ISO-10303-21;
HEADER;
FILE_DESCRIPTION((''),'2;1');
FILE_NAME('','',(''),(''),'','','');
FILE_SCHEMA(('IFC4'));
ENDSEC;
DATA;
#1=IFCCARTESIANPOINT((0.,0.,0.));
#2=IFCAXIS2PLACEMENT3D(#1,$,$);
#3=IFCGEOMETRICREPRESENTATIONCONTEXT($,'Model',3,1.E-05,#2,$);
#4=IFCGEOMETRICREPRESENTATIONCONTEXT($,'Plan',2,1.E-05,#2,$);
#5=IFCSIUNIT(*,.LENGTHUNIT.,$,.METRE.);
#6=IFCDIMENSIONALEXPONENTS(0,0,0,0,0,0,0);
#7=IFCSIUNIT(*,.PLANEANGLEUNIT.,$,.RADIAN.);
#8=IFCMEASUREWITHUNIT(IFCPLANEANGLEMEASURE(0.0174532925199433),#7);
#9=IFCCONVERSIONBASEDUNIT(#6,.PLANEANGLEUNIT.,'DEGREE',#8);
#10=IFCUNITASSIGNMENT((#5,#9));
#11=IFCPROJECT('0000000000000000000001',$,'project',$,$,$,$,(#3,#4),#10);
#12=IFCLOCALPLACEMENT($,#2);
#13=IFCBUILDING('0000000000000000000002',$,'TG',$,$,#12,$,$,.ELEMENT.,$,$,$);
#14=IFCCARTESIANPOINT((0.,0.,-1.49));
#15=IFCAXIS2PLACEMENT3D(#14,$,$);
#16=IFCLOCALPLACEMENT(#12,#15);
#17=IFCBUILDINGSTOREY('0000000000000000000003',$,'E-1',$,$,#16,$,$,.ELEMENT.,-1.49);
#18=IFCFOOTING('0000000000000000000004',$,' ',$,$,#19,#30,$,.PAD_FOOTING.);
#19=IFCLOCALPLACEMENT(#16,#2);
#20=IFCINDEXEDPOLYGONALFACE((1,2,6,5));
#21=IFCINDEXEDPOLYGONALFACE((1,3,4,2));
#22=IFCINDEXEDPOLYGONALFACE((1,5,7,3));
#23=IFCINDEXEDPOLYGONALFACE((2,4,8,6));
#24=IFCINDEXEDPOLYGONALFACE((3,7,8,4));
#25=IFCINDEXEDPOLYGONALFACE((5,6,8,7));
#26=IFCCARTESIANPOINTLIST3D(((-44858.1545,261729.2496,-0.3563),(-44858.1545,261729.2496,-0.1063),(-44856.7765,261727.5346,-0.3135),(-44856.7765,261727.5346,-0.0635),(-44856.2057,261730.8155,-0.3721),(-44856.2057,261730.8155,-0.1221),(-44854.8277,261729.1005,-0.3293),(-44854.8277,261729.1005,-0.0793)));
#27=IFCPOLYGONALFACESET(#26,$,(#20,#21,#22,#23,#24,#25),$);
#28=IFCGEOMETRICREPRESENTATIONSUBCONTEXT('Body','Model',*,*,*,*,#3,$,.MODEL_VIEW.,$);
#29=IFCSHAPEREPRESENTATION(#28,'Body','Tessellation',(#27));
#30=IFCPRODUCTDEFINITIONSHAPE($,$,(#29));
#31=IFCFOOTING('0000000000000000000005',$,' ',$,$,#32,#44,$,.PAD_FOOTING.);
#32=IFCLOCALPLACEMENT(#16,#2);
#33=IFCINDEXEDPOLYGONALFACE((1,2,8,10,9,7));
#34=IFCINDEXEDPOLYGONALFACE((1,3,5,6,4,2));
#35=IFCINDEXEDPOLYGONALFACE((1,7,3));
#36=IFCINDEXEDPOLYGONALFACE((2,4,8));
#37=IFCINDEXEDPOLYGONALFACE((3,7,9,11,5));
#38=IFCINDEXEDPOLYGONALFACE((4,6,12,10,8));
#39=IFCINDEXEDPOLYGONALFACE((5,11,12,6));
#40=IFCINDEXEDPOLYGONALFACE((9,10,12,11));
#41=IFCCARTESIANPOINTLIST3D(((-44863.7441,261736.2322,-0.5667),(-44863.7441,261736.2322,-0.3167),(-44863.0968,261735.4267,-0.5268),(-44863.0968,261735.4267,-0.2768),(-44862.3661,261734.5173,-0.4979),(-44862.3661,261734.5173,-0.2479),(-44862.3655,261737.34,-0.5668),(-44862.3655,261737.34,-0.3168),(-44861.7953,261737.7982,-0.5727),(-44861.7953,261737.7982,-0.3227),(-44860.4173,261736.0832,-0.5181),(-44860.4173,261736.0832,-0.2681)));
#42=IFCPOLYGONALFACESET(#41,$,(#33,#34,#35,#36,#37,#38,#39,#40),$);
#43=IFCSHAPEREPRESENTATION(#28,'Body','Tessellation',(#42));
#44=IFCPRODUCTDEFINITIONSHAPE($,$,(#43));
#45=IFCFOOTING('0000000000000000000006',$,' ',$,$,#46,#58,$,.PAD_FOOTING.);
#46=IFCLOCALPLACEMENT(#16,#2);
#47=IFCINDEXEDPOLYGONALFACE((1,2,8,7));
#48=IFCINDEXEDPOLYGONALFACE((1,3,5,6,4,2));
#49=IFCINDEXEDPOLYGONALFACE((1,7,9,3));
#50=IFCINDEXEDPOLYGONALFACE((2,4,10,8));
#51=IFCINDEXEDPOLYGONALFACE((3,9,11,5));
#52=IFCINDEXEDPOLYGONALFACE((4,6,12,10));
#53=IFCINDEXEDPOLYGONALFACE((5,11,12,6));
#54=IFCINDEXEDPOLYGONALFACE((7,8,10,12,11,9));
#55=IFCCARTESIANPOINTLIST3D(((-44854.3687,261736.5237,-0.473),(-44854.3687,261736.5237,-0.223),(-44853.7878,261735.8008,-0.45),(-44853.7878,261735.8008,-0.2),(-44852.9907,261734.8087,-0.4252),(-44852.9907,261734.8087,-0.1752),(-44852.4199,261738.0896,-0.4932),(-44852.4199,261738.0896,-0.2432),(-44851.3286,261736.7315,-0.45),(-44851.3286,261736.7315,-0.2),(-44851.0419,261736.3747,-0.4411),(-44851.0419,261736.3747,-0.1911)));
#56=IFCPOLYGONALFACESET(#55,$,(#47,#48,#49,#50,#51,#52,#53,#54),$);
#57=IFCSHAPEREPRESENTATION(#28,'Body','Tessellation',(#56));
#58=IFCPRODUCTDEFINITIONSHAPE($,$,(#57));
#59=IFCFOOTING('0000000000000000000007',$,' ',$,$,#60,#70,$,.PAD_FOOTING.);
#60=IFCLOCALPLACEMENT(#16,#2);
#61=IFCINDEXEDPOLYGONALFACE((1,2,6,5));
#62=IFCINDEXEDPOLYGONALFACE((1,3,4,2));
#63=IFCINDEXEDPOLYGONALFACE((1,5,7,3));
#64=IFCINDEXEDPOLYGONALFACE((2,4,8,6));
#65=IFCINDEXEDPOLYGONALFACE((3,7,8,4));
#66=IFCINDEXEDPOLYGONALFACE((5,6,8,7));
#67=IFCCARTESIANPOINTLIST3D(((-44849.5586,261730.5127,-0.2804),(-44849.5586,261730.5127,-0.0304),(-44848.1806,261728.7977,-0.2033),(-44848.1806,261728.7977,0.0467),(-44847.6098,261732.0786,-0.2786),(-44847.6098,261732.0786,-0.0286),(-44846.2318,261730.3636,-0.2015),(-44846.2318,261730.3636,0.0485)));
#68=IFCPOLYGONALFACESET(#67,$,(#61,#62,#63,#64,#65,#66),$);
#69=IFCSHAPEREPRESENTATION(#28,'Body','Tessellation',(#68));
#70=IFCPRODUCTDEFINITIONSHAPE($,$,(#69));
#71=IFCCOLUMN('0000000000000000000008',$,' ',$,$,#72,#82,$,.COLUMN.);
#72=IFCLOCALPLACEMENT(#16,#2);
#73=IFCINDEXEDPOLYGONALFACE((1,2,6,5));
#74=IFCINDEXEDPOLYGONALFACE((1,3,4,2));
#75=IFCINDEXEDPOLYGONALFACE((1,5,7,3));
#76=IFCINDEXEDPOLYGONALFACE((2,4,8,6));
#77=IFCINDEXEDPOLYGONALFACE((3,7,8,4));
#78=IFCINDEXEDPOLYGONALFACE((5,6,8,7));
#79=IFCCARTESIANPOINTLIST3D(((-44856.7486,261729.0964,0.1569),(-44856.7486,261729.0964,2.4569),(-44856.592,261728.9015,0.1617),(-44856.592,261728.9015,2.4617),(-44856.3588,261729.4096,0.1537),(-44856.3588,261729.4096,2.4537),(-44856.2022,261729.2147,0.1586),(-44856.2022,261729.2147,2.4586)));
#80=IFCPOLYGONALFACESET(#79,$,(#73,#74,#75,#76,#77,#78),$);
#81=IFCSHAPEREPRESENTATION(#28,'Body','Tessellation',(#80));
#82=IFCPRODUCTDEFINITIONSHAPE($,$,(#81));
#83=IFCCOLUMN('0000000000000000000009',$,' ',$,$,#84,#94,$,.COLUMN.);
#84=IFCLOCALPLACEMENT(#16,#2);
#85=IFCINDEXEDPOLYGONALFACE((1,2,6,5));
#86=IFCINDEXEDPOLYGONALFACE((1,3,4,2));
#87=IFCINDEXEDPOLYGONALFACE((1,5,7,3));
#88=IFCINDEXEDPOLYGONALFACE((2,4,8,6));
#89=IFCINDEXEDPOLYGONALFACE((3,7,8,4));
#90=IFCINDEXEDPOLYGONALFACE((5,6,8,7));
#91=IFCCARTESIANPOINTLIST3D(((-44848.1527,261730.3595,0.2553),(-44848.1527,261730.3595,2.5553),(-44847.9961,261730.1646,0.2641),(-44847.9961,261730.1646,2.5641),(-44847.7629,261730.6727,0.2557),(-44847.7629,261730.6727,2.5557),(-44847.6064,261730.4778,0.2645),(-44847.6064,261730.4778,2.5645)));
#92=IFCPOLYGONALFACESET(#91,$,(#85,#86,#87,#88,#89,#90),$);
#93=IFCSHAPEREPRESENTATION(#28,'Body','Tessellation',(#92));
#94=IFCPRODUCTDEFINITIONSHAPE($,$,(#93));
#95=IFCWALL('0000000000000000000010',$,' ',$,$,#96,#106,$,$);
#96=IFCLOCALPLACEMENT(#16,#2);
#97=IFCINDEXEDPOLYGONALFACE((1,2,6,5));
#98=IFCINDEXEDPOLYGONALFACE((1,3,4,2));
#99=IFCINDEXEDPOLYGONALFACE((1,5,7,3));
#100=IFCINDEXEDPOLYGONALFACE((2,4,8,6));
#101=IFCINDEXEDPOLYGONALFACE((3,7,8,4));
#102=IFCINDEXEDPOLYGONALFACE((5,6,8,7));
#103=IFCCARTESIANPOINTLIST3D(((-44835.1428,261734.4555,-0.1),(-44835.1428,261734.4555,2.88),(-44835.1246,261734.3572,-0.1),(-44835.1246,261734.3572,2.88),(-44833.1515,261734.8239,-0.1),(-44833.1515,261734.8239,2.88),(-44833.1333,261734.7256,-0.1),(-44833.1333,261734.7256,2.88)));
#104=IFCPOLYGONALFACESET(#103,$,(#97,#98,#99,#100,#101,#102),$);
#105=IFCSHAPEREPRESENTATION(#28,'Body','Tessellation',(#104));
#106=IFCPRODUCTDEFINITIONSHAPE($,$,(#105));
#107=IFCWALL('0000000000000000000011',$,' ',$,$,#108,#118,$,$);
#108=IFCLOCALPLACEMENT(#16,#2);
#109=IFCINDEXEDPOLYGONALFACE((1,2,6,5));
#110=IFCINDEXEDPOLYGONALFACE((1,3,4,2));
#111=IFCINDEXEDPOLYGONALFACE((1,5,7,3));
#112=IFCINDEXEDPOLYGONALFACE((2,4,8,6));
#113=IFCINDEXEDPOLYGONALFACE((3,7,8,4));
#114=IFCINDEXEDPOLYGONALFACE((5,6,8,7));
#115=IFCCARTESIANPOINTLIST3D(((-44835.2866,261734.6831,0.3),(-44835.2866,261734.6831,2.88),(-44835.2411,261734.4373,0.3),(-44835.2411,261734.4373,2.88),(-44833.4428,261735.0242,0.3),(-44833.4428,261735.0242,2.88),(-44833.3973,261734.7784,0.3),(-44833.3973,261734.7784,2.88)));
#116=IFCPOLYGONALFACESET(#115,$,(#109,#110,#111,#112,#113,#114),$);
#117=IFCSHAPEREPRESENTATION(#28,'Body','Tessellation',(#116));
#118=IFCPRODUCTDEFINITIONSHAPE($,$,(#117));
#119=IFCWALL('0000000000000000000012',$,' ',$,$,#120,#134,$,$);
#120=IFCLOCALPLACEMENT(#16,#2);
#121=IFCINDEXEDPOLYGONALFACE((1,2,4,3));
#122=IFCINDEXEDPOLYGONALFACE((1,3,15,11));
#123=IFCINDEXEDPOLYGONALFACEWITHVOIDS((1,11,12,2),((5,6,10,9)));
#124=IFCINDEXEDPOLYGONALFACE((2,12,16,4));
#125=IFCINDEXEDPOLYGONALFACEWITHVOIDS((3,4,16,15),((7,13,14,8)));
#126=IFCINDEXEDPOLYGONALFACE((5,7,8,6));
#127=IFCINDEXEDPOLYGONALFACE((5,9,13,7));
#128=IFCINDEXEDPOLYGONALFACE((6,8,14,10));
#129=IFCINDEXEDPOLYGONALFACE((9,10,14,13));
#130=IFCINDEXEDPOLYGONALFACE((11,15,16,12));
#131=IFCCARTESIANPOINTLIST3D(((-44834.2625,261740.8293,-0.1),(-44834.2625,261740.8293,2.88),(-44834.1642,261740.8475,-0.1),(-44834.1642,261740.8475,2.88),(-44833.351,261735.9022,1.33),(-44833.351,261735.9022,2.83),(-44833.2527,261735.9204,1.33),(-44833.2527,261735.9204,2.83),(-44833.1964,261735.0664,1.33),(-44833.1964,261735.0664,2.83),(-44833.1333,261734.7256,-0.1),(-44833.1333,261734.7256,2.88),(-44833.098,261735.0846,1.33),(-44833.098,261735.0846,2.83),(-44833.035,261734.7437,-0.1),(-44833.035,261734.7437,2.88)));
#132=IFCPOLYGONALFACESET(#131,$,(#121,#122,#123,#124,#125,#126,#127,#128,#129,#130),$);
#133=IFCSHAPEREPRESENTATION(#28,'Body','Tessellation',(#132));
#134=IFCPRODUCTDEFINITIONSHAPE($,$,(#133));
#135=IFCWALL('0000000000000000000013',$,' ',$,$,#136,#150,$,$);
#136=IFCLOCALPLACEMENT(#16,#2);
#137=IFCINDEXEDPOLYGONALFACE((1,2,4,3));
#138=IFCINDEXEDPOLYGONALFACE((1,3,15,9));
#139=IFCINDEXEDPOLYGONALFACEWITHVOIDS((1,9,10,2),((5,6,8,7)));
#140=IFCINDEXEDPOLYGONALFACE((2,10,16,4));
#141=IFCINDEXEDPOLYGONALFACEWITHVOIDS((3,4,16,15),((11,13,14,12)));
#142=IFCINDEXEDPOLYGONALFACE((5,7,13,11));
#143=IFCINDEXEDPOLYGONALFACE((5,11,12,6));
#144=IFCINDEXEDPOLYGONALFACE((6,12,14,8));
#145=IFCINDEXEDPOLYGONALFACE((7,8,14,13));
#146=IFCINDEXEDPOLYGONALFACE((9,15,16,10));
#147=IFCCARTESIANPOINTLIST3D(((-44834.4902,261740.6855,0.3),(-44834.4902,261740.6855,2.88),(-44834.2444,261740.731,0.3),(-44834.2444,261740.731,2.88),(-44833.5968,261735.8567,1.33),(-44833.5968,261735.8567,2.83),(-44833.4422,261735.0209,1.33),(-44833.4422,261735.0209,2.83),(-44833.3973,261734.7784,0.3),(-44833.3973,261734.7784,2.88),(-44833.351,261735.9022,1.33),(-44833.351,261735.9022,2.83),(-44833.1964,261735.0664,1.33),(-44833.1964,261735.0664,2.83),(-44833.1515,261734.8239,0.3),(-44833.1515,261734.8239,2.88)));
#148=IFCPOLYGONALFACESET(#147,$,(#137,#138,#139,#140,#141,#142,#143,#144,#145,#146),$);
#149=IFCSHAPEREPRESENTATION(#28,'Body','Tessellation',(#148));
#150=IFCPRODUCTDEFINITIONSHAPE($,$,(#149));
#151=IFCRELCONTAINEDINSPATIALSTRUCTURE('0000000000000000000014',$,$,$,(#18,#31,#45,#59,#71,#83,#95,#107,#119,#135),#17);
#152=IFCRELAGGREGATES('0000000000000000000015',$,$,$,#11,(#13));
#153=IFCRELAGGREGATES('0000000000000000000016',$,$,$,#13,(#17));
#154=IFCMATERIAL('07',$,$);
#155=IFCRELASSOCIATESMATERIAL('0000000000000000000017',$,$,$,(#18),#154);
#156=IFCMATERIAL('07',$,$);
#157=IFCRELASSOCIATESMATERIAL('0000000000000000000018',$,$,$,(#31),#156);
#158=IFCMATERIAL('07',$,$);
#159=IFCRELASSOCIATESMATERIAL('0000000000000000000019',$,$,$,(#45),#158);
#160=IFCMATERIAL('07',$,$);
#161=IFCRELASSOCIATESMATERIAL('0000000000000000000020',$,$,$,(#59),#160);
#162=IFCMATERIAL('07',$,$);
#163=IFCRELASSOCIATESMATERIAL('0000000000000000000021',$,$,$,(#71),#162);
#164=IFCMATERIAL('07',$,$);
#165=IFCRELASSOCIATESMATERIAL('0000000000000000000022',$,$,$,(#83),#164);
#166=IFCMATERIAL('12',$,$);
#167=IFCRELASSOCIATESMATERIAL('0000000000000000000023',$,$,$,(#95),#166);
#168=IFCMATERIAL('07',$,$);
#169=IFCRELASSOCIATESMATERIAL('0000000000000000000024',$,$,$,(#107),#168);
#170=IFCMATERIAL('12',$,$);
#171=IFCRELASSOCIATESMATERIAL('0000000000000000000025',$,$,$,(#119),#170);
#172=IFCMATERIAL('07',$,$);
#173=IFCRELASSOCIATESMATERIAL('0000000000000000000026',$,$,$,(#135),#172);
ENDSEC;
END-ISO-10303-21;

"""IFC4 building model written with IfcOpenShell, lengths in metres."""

from ifc_helpers import new_model, entity, si_unit, converted_unit, frame, frame_2d, origin, origin_with_axes, place, context, subcontext, project, spatial, polyline, rectangle, outline, extrude, clip, halfspace, bounded_halfspace, material, element, save


model = new_model("IFC4")

# Units and contexts
model_context = context("Model", 3, precision=1e-05, world=origin())
plan_context = context("Plan", 2, precision=1e-05, world=origin())
body_context = subcontext(model_context, "Body", "Model", "MODEL_VIEW")
ifc_project = project(units=[si_unit("LENGTHUNIT", "METRE"), converted_unit("PLANEANGLEUNIT", "DEGREE", entity("IfcPlaneAngleMeasure", 0.0174532925199433), si_unit("PLANEANGLEUNIT", "RADIAN"), dimensions=[0, 0, 0, 0, 0, 0, 0])], contexts=[model_context, plan_context])

# Building, storey
building_placement = place(None, origin())
building = spatial("IfcBuilding", under=ifc_project, at=building_placement, Name="TG", CompositionType="ELEMENT")
storey_placement = place(building_placement, frame((0.0, 0.0, -1.49)))
storey = spatial("IfcBuildingStorey", under=building, at=storey_placement, Name="E-1", CompositionType="ELEMENT", Elevation=-1.49)

# Footings
ifc_material_1 = material(Name="07")
footing_1_placement = place(storey_placement, frame((-44858.1545, 261727.5346, -0.3721)))
element("IfcFooting", 1, at=footing_1_placement, inside=storey, material=ifc_material_1, Name=" ", PredefinedType="PAD_FOOTING", context=body_context, shape_type="Clipping", body=[
    clip(clip(extrude(rectangle(XDim=2.5, YDim=2.2, at=frame_2d((0.2854, 1.6404), x_axis=(0.779531, 0.626364))), frame((1.378, 0.0, 0.0), z_axis=(0.0, 0.0, 1.0), x_axis=(1.0, 0.0, 0.0)), (0.0, 0.0, 1.0), 0.3087), halfspace(frame((1.6634, 1.6404, 0.0293), z_axis=(-0.00724, 0.019133, 0.999791), x_axis=(0.626245, -0.779383, 0.01945)), True)), halfspace(frame((1.6634, 1.6404, 0.2793), z_axis=(0.00724, -0.019133, -0.999791), x_axis=(0.779515, 0.626351, -0.006341)), True)),
])
ifc_material_2 = material(Name="07")
footing_2_placement = place(storey_placement, frame((-44863.7441, 261734.5173, -0.5727)))
element("IfcFooting", 2, at=footing_2_placement, inside=storey, material=ifc_material_2, Name=" ", PredefinedType="PAD_FOOTING", context=body_context, shape_type="Clipping", body=[
    clip(clip(clip(clip(extrude(rectangle(XDim=2.5, YDim=2.2, at=frame_2d((0.2854, 1.6404), x_axis=(0.779531, 0.626364))), frame((1.378, 0.0, 0.0), z_axis=(0.0, 0.0, 1.0), x_axis=(1.0, 0.0, 0.0)), (0.0, 0.0, 1.0), 0.3248), bounded_halfspace(frame((1.7359, 1.7158, 0.0362), z_axis=(-0.009231, 0.024393, 0.99966), x_axis=(-0.626171, 0.779291, -0.024798)), True, origin_with_axes(), polyline([(3.3268, 1.5659), (1.9488, 3.2809), (1.3787, 2.8227), (0.6473, 0.9094), (1.378, 0.0), (3.3268, 1.5659)]))), bounded_halfspace(frame((0.6753, 1.8157, 0.0193), z_axis=(-0.024077, 0.03006, 0.999258), x_axis=(0.356977, 0.93391, -0.019493)), True, origin_with_axes(), polyline([(0.6473, 0.9094), (1.3787, 2.8227), (0.0, 1.715), (0.6473, 0.9094)]))), bounded_halfspace(frame((1.7359, 1.7158, 0.2862), z_axis=(0.009231, -0.024393, -0.99966), x_axis=(-0.779505, -0.626343, 0.008086)), True, origin_with_axes(), polyline([(1.9488, 3.2809), (1.3787, 2.8227), (0.6473, 0.9094), (1.378, 0.0), (3.3268, 1.5659), (1.9488, 3.2809)]))), bounded_halfspace(frame((0.6753, 1.8157, 0.2693), z_axis=(0.024077, -0.03006, -0.999258), x_axis=(-0.779531, -0.626364, 0.00006)), True, origin_with_axes(), polyline([(1.3787, 2.8227), (0.0, 1.715), (0.6473, 0.9094), (1.3787, 2.8227)]))),
])
ifc_material_3 = material(Name="07")
footing_3_placement = place(storey_placement, frame((-44854.3687, 261734.8087, -0.4932)))
element("IfcFooting", 3, at=footing_3_placement, inside=storey, material=ifc_material_3, Name=" ", PredefinedType="PAD_FOOTING", context=body_context, shape_type="Clipping", body=[
    clip(clip(clip(clip(extrude(rectangle(XDim=2.5, YDim=2.2, at=frame_2d((0.2854, 1.6404), x_axis=(0.779531, 0.626364))), frame((1.378, 0.0, 0.0), z_axis=(0.0, 0.0, 1.0), x_axis=(1.0, 0.0, 0.0)), (0.0, 0.0, 1.0), 0.318), bounded_halfspace(frame((2.0815, 1.1202, 0.0516), z_axis=(-0.00724, 0.019133, 0.999791), x_axis=(0.779515, 0.626351, -0.006341)), True, origin_with_axes(), polyline([(1.378, 0.0), (3.3268, 1.5659), (3.0401, 1.9227), (0.5809, 0.9921), (1.378, 0.0)]))), bounded_halfspace(frame((1.3925, 1.9777, 0.0267), z_axis=(-0.009231, 0.024393, 0.99966), x_axis=(0.626171, -0.779291, 0.024798)), True, origin_with_axes(), polyline([(0.0, 1.715), (0.5809, 0.9921), (3.0401, 1.9227), (1.9488, 3.2809), (0.0, 1.715)]))), bounded_halfspace(frame((2.0815, 1.1202, 0.3016), z_axis=(0.00724, -0.019133, -0.999791), x_axis=(-0.626245, 0.779383, -0.01945)), True, origin_with_axes(), polyline([(3.3268, 1.5659), (3.0401, 1.9227), (0.5809, 0.9921), (1.378, 0.0), (3.3268, 1.5659)]))), bounded_halfspace(frame((1.3925, 1.9777, 0.2767), z_axis=(0.009231, -0.024393, -0.99966), x_axis=(0.935274, 0.353924, 0.0)), True, origin_with_axes(), polyline([(0.5809, 0.9921), (3.0401, 1.9227), (1.9488, 3.2809), (0.0, 1.715), (0.5809, 0.9921)]))),
])
ifc_material_4 = material(Name="07")
footing_4_placement = place(storey_placement, frame((-44849.5586, 261728.7977, -0.2804)))
element("IfcFooting", 4, at=footing_4_placement, inside=storey, material=ifc_material_4, Name=" ", PredefinedType="PAD_FOOTING", context=body_context, shape_type="Clipping", body=[
    clip(clip(extrude(rectangle(XDim=2.5, YDim=2.2, at=frame_2d((0.2854, 1.6404), x_axis=(0.779531, 0.626364))), frame((1.378, 0.0, 0.0), z_axis=(0.0, 0.0, 1.0), x_axis=(1.0, 0.0, 0.0)), (0.0, 0.0, 1.0), 0.3289), halfspace(frame((1.6634, 1.6404, 0.0395), z_axis=(-0.022501, 0.026849, 0.999386), x_axis=(0.62598, -0.779053, 0.035023)), True)), halfspace(frame((1.6634, 1.6404, 0.2895), z_axis=(0.022501, -0.026849, -0.999386), x_axis=(0.779531, 0.626364, 0.000723)), True)),
])

# Columns
ifc_material_5 = material(Name="07")
column_1_placement = place(storey_placement, frame((-44856.3588, 261729.4096, 0.1537)))
element("IfcColumn", 5, at=column_1_placement, inside=storey, material=ifc_material_5, Name=" ", PredefinedType="COLUMN", context=body_context, shape_type="Clipping", body=[
    clip(clip(extrude(rectangle(XDim=0.5, YDim=0.25, at=frame_2d((-0.1166, -0.254), x_axis=(-0.779531, -0.626364))), origin_with_axes(), (0.0, 0.0, 1.0), 2.308), halfspace(frame((-0.1166, -0.254, 0.004), z_axis=(-0.00724, 0.019133, 0.999791), x_axis=(-0.626245, 0.779383, -0.01945)), True)), halfspace(frame((-0.1166, -0.254, 2.304), z_axis=(0.00724, -0.019133, -0.999791), x_axis=(-0.779515, -0.626351, 0.006341)), True)),
])
ifc_material_6 = material(Name="07")
column_2_placement = place(storey_placement, frame((-44847.7629, 261730.6727, 0.2553)))
element("IfcColumn", 6, at=column_2_placement, inside=storey, material=ifc_material_6, Name=" ", PredefinedType="COLUMN", context=body_context, shape_type="Clipping", body=[
    clip(clip(extrude(rectangle(XDim=0.5, YDim=0.25, at=frame_2d((-0.1166, -0.254), x_axis=(-0.779531, -0.626364))), origin_with_axes(), (0.0, 0.0, 1.0), 2.3091), halfspace(frame((-0.1166, -0.254, 0.0046), z_axis=(-0.022501, 0.026849, 0.999386), x_axis=(-0.62598, 0.779053, -0.035023)), True)), halfspace(frame((-0.1166, -0.254, 2.3046), z_axis=(0.022501, -0.026849, -0.999386), x_axis=(-0.779531, -0.626364, -0.000723)), True)),
])

# Walls
ifc_material_7 = material(Name="12")
wall_1_placement = place(storey_placement, frame((-44835.1246, 261734.3572, -0.1), z_axis=(0.0, 0.0, 1.0), x_axis=(0.983313, 0.18192, 0.0)))
element("IfcWall", 7, at=wall_1_placement, inside=storey, material=ifc_material_7, Name=" ", context=body_context, shape_type="SweptSolid", body=[
    extrude(rectangle(XDim=2.0251, YDim=0.1, at=frame_2d((1.0125, 0.05), x_axis=(1.0, 0.0))), origin_with_axes(), (0.0, 0.0, 1.0), 2.98),
])
ifc_material_8 = material(Name="07")
wall_2_placement = place(storey_placement, frame((-44835.2411, 261734.4373, 0.3), z_axis=(0.0, 0.0, 1.0), x_axis=(0.983313, 0.18192, 0.0)))
element("IfcWall", 8, at=wall_2_placement, inside=storey, material=ifc_material_8, Name=" ", context=body_context, shape_type="SweptSolid", body=[
    extrude(rectangle(XDim=1.8751, YDim=0.25, at=frame_2d((0.9375, 0.125), x_axis=(1.0, 0.0))), origin_with_axes(), (0.0, 0.0, 1.0), 2.58),
])

# Walls, openings
ifc_material_9 = material(Name="12")
wall_3_placement = place(storey_placement, frame((-44833.035, 261734.7437, -0.1), z_axis=(0.0, 0.0, 1.0), x_axis=(-0.18192, 0.983313, 0.0)))
wall_3 = element("IfcWall", 9, at=wall_3_placement, inside=storey, material=ifc_material_9, Name=" ", context=body_context, shape_type="SweptSolid", body=[
    extrude(rectangle(XDim=6.2074, YDim=0.1, at=frame_2d((3.1037, 0.05), x_axis=(1.0, 0.0))), origin_with_axes(), (0.0, 0.0, 1.0), 2.98),
])
opening_1_placement = place(wall_3_placement, frame((1.1966, 0.1, 1.43), z_axis=(0.0, -1.0, 0.0), x_axis=(0.0, 0.0, 1.0)))
element("IfcOpeningElement", 10, at=opening_1_placement, cuts=wall_3, ObjectType="Opening", context=body_context, shape_type="SweptSolid", body=[
    extrude(outline(polyline([(0.0, 0.85), (1.5, 0.85), (1.5, 0.0), (0.0, 0.0), (0.0, 0.85)])), origin_with_axes(), (0.0, 0.0, 1.0), 0.1),
])
ifc_material_10 = material(Name="07")
wall_4_placement = place(storey_placement, frame((-44833.1515, 261734.8239, 0.3), z_axis=(0.0, 0.0, 1.0), x_axis=(-0.18192, 0.983313, 0.0)))
wall_4 = element("IfcWall", 11, at=wall_4_placement, inside=storey, material=ifc_material_10, Name=" ", context=body_context, shape_type="SweptSolid", body=[
    extrude(rectangle(XDim=6.0074, YDim=0.25, at=frame_2d((3.0037, 0.125), x_axis=(1.0, 0.0))), origin_with_axes(), (0.0, 0.0, 1.0), 2.58),
])
opening_2_placement = place(wall_4_placement, frame((1.0966, 0.25, 1.03), z_axis=(0.0, -1.0, 0.0), x_axis=(0.0, 0.0, 1.0)))
element("IfcOpeningElement", 12, at=opening_2_placement, cuts=wall_4, ObjectType="Opening", context=body_context, shape_type="SweptSolid", body=[
    extrude(outline(polyline([(0.0, 0.85), (1.5, 0.85), (1.5, 0.0), (0.0, 0.0), (0.0, 0.85)])), origin_with_axes(), (0.0, 0.0, 1.0), 0.25),
])

save(model, "model.ifc")
